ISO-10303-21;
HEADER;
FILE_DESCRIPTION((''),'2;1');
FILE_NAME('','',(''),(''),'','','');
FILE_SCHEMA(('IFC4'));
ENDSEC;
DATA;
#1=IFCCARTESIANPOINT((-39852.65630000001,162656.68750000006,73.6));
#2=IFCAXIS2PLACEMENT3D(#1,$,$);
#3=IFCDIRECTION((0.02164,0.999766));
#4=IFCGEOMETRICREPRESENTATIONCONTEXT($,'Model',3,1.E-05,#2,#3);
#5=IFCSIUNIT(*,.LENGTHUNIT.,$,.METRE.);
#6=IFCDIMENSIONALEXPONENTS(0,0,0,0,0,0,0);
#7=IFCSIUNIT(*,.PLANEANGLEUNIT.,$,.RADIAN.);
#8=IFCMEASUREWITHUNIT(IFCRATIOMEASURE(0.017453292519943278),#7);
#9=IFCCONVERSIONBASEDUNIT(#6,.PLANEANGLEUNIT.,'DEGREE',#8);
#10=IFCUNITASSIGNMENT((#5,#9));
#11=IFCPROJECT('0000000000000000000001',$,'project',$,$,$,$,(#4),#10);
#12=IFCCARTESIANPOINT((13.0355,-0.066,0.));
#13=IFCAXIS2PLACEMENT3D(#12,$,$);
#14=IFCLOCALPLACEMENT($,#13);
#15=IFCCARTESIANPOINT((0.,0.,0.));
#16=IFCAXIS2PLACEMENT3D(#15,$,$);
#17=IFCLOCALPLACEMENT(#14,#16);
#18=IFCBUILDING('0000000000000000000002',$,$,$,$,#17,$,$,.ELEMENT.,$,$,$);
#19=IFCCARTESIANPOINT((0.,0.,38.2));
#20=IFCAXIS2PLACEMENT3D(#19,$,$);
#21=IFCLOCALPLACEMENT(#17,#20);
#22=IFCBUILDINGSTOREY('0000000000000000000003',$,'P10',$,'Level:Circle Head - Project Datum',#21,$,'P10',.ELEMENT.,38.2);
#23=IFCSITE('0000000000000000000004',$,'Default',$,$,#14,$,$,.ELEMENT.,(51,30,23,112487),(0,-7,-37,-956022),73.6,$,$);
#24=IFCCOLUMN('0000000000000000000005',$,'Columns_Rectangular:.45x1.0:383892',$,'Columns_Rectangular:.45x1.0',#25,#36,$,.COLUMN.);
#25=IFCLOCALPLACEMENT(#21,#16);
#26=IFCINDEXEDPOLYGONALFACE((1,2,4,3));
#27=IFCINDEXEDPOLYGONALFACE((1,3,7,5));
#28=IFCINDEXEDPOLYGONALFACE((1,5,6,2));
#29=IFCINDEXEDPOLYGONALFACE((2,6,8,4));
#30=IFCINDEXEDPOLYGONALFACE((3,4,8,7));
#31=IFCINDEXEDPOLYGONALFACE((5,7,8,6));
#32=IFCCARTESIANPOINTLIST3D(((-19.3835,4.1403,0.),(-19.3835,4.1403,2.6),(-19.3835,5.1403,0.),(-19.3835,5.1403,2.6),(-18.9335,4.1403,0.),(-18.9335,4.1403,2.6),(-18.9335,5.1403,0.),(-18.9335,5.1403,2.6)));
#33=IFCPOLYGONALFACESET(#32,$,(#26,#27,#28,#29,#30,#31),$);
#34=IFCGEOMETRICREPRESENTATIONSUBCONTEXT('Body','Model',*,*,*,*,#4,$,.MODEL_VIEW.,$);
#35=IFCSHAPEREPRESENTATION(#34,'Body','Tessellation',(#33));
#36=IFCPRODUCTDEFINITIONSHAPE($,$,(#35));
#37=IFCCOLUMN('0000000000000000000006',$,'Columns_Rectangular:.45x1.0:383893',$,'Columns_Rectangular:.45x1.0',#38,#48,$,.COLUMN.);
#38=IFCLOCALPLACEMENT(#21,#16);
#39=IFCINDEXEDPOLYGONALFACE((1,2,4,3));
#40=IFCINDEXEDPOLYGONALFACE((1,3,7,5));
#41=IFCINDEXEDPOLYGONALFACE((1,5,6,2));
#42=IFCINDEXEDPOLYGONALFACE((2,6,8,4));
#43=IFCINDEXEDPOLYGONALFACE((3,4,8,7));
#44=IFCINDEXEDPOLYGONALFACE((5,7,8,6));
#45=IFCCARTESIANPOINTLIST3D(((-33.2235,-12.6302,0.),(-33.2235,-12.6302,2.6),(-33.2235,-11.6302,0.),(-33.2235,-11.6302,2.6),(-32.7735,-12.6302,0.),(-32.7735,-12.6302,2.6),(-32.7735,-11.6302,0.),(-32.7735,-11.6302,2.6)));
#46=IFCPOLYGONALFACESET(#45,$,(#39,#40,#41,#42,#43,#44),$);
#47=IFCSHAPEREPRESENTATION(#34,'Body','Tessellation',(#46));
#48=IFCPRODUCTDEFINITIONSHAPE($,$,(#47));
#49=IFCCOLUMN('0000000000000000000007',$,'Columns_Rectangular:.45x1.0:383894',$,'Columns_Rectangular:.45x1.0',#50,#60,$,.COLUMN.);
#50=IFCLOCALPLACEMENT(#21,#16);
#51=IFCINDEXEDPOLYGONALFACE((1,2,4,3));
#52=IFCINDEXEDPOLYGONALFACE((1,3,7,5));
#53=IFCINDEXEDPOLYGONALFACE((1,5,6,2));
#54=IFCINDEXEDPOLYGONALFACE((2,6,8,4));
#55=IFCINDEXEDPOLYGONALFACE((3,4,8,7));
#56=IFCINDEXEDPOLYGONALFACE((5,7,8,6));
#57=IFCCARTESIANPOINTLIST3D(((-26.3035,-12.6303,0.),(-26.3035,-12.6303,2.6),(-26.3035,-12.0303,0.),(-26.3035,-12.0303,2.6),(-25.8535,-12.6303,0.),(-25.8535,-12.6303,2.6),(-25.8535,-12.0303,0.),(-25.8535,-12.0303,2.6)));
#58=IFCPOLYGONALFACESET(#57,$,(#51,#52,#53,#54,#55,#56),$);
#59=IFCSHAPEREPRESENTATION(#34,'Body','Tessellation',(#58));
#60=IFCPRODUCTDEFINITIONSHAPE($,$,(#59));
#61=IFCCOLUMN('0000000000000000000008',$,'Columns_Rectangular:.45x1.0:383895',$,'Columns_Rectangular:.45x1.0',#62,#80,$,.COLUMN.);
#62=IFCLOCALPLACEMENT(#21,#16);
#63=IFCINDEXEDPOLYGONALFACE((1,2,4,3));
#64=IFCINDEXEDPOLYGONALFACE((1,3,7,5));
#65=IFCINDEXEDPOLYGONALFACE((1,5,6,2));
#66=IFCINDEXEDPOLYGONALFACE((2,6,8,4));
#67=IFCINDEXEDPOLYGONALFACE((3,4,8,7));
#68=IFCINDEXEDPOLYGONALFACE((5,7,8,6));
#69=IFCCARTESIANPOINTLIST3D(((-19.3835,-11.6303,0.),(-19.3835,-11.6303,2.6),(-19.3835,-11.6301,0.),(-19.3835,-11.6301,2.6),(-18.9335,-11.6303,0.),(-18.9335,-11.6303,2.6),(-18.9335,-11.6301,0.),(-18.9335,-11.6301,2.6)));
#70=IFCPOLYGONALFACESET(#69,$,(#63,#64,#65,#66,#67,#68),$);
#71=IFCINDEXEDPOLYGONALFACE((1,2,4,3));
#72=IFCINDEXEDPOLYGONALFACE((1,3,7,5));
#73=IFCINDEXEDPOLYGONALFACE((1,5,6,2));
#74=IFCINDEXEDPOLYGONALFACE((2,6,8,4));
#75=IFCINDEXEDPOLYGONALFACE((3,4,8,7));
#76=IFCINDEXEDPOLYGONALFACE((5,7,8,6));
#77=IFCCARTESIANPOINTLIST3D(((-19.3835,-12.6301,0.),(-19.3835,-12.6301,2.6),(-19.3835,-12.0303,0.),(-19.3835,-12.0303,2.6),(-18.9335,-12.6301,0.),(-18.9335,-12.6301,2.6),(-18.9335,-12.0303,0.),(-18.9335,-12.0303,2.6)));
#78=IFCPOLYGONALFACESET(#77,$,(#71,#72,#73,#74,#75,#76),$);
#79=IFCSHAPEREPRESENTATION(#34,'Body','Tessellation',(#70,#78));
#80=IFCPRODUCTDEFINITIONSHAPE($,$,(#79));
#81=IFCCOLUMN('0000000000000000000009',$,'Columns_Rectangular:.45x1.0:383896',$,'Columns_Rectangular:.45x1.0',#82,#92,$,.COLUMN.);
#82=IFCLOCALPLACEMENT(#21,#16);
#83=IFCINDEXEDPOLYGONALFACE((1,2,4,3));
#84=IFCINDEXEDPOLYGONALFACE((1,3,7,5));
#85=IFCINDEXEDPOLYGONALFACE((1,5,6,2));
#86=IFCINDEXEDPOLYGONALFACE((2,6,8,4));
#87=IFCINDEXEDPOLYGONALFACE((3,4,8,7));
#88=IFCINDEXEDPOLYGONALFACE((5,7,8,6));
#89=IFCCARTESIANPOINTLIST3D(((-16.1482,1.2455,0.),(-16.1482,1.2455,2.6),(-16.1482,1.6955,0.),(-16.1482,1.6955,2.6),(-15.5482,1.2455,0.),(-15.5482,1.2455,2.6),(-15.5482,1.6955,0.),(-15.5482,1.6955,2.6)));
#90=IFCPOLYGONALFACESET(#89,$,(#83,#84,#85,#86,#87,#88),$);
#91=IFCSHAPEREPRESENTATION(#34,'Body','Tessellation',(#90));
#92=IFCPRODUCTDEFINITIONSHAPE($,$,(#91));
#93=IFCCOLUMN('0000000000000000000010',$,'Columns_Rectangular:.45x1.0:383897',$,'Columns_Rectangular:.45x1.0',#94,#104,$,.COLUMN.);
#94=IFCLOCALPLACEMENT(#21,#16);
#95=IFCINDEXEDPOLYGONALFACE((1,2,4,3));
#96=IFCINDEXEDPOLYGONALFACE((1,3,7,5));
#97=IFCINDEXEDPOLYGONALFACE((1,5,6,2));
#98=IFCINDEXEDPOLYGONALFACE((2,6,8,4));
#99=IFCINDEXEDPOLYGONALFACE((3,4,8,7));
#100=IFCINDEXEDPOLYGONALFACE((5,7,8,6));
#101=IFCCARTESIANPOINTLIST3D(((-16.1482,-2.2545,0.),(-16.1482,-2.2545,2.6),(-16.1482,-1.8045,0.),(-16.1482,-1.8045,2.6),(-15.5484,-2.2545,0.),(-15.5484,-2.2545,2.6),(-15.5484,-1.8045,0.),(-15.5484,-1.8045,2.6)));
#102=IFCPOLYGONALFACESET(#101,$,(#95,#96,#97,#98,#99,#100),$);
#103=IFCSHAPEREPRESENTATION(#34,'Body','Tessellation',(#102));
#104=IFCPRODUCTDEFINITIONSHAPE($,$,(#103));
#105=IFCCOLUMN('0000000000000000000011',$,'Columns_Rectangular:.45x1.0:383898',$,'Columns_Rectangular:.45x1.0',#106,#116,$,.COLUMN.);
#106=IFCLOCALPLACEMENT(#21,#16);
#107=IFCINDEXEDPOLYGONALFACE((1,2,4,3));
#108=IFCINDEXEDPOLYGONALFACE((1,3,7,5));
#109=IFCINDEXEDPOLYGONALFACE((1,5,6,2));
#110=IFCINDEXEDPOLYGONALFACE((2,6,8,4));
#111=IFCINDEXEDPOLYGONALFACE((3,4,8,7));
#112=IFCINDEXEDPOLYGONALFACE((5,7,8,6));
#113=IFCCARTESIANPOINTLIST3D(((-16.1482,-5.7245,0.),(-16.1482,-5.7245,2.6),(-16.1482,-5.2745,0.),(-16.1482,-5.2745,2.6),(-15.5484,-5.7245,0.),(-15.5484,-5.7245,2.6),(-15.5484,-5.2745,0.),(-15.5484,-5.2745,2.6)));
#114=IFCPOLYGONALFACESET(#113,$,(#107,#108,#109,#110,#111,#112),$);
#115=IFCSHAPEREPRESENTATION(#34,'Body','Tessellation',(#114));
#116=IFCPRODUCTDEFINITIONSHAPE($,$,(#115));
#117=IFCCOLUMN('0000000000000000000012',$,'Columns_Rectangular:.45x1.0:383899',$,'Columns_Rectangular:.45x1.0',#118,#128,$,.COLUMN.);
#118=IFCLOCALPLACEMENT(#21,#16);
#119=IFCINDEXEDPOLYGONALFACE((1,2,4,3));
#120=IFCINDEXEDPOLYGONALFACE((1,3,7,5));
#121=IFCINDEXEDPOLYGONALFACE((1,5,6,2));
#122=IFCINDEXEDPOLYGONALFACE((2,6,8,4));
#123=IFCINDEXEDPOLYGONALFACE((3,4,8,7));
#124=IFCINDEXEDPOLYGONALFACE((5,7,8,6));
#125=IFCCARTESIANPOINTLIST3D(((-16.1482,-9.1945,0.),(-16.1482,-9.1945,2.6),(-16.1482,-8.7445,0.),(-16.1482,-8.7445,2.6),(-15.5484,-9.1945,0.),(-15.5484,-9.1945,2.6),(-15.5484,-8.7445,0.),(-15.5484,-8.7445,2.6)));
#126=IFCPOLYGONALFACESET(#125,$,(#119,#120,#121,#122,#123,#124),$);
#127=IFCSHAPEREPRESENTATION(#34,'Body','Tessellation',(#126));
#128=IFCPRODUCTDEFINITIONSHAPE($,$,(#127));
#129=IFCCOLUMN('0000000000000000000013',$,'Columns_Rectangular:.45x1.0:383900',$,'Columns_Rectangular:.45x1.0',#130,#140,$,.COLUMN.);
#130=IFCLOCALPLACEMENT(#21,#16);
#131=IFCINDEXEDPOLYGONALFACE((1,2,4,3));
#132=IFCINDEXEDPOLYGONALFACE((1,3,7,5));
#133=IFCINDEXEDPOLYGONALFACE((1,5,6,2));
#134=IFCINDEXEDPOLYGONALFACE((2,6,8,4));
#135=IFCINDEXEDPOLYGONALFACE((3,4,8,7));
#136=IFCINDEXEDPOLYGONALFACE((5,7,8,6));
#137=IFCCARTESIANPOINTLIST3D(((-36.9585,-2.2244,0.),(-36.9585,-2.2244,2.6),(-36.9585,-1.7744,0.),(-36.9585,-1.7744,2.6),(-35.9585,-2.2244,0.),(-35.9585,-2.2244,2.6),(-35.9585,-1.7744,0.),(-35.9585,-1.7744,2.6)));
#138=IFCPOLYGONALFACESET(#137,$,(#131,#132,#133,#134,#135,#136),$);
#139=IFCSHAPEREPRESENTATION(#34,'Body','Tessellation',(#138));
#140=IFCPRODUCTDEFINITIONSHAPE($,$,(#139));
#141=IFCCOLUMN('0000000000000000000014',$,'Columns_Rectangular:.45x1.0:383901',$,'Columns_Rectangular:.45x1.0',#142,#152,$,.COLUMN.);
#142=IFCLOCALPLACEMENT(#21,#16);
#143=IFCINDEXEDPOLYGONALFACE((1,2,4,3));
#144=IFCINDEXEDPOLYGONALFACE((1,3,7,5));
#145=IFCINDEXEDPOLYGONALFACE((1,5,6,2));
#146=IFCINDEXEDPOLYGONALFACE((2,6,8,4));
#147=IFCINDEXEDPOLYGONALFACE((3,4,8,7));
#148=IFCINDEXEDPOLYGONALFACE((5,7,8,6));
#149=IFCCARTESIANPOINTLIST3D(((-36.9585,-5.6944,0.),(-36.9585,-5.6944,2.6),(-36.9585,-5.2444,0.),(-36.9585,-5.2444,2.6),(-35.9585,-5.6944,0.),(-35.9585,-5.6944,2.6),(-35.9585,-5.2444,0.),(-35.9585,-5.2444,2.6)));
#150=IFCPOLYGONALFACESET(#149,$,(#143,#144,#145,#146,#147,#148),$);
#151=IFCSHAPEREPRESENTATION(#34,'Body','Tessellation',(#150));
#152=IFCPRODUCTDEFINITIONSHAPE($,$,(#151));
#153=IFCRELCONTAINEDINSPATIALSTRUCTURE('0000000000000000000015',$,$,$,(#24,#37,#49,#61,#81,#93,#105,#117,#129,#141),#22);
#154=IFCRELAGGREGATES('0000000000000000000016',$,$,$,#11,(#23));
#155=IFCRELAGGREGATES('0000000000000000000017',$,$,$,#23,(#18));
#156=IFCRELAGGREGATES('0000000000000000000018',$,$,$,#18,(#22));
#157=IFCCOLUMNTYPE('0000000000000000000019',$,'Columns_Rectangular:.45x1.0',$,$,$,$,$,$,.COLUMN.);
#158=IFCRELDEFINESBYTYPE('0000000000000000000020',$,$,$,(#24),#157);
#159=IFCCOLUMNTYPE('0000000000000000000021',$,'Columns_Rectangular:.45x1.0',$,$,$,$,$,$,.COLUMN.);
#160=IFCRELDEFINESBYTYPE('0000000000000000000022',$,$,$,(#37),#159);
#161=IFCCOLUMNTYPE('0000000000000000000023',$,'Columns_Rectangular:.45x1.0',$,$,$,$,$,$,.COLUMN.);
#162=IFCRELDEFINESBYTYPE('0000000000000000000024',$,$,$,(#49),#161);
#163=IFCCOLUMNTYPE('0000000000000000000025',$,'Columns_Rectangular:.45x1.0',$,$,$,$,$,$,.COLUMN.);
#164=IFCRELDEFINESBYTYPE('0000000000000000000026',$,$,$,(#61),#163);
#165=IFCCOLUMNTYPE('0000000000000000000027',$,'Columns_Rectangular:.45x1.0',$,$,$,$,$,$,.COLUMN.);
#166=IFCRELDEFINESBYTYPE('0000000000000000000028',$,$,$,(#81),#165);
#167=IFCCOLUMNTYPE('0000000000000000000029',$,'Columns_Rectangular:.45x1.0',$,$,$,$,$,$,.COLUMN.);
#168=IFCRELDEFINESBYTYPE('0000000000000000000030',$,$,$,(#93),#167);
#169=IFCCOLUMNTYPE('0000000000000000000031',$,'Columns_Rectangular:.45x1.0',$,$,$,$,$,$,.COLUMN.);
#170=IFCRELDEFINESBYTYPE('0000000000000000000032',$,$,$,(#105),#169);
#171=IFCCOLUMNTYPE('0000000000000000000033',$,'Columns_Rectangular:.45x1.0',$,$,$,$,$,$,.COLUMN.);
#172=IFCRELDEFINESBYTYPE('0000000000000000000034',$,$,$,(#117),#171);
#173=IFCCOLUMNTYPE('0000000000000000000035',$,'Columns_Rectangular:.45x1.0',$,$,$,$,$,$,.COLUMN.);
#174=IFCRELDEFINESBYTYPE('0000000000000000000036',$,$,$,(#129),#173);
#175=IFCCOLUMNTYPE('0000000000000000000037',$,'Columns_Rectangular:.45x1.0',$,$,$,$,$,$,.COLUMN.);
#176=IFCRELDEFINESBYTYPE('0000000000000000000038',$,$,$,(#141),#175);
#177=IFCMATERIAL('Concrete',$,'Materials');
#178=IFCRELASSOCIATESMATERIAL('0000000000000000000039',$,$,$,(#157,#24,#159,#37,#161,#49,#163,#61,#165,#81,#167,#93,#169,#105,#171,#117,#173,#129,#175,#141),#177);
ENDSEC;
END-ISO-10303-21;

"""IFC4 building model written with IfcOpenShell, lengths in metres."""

from ifc_helpers import new_model, entity, si_unit, converted_unit, direction, frame, origin, place, context, subcontext, project, spatial, indexed_curve, outline, extrude, source, transform, mapped, material, type_object, type_shapes, element, save


model = new_model("IFC4")

# Units and contexts
model_context = context("Model", 3, precision=1e-05, world=frame((-39852.65630000001, 162656.68750000006, 73.6)), true_north=direction((0.02164, 0.999766)))
body_context = subcontext(model_context, "Body", "Model", "MODEL_VIEW")
ifc_project = project(units=[si_unit("LENGTHUNIT", "METRE"), converted_unit("PLANEANGLEUNIT", "DEGREE", entity("IfcRatioMeasure", 0.017453292519943278), si_unit("PLANEANGLEUNIT", "RADIAN"), dimensions=[0, 0, 0, 0, 0, 0, 0])], contexts=[model_context])

# Site, building, storey
site_placement = place(None, frame((13.0355, -0.066, 0.0)))
site = spatial("IfcSite", under=ifc_project, at=site_placement, Name="Default", CompositionType="ELEMENT", RefLatitude=(51, 30, 23, 112487), RefLongitude=(0, -7, -37, -956022), RefElevation=73.6)
building_placement = place(site_placement, origin())
building = spatial("IfcBuilding", under=site, at=building_placement, CompositionType="ELEMENT")
storey_placement = place(building_placement, frame((0.0, 0.0, 38.2)))
storey = spatial("IfcBuildingStorey", under=building, at=storey_placement, Name="P10", ObjectType="Level:Circle Head - Project Datum", LongName="P10", CompositionType="ELEMENT", Elevation=38.2)

# Columns
ifc_material = material(Name="Concrete", Category="Materials")
column_type_1 = type_object("IfcColumnType", Name="Columns_Rectangular:.45x1.0", PredefinedType="COLUMN", material=ifc_material)
shared_shape_1 = source(origin(), body_context, "Body", "SweptSolid", [
    extrude(outline(indexed_curve([(-0.5, -0.225), (0.5, -0.225), (0.5, 0.225), (-0.5, 0.225), (-0.5, -0.225)], self_intersect=False)), frame((-19.1585, 4.6403, 38.2), z_axis=(0.0, 0.0, 1.0), x_axis=(0.000016, 1.0, 0.0)), (0.0, 0.0, 1.0), 2.6),
])
type_shapes(column_type_1, [shared_shape_1])
column_1_placement = place(storey_placement, frame((0.0, 0.0, -38.2)))
element("IfcColumn", 1, at=column_1_placement, inside=storey, type_object=column_type_1, material=ifc_material, Name="Columns_Rectangular:.45x1.0:383892", ObjectType="Columns_Rectangular:.45x1.0", PredefinedType="COLUMN", context=body_context, shape_type="MappedRepresentation", body=[
    mapped(shared_shape_1, transform((0.0, 0.0, 0.0), scale=1.0)),
])
column_type_2 = type_object("IfcColumnType", Name="Columns_Rectangular:.45x1.0", PredefinedType="COLUMN", material=ifc_material)
shared_shape_2 = source(origin(), body_context, "Body", "SweptSolid", [
    extrude(outline(indexed_curve([(-0.5, -0.225), (0.5, -0.225), (0.5, 0.225), (-0.5, 0.225), (-0.5, -0.225)], self_intersect=False)), frame((-32.9985, -12.1302, 38.2), z_axis=(0.0, 0.0, 1.0), x_axis=(-0.000005, 1.0, 0.0)), (0.0, 0.0, 1.0), 2.6),
])
type_shapes(column_type_2, [shared_shape_2])
column_2_placement = place(storey_placement, frame((0.0, 0.0, -38.2)))
element("IfcColumn", 2, at=column_2_placement, inside=storey, type_object=column_type_2, material=ifc_material, Name="Columns_Rectangular:.45x1.0:383893", ObjectType="Columns_Rectangular:.45x1.0", PredefinedType="COLUMN", context=body_context, shape_type="MappedRepresentation", body=[
    mapped(shared_shape_2, transform((0.0, 0.0, 0.0), scale=1.0)),
])
column_type_3 = type_object("IfcColumnType", Name="Columns_Rectangular:.45x1.0", PredefinedType="COLUMN", material=ifc_material)
shared_shape_3 = source(origin(), body_context, "Body", "SweptSolid", [
    extrude(outline(indexed_curve([(-0.3, -0.225), (0.3, -0.225), (0.3, 0.225), (-0.3, 0.225), (-0.3, -0.225)], self_intersect=False)), frame((-26.0785, -12.3303, 38.2), z_axis=(0.0, 0.0, 1.0), x_axis=(0.000011, 1.0, 0.0)), (0.0, 0.0, 1.0), 2.6),
])
type_shapes(column_type_3, [shared_shape_3])
column_3_placement = place(storey_placement, frame((0.0, 0.0, -38.2)))
element("IfcColumn", 3, at=column_3_placement, inside=storey, type_object=column_type_3, material=ifc_material, Name="Columns_Rectangular:.45x1.0:383894", ObjectType="Columns_Rectangular:.45x1.0", PredefinedType="COLUMN", context=body_context, shape_type="MappedRepresentation", body=[
    mapped(shared_shape_3, transform((0.0, 0.0, 0.0), scale=1.0)),
])
column_type_4 = type_object("IfcColumnType", Name="Columns_Rectangular:.45x1.0", PredefinedType="COLUMN", material=ifc_material)
shared_shape_4 = source(origin(), body_context, "Body", "SweptSolid", [
    extrude(outline(indexed_curve([(-0.225, -0.0001), (0.225, -0.0001), (0.225, 0.0001), (-0.225, 0.0001), (-0.225, -0.0001)], self_intersect=False)), frame((-19.1585, -11.6302, 38.2), z_axis=(0.0, 0.0, 1.0), x_axis=(-1.0, 0.000011, 0.0)), (0.0, 0.0, 1.0), 2.6),
    extrude(outline(indexed_curve([(-0.2999, -0.225), (0.2999, -0.225), (0.2999, 0.225), (-0.2999, 0.225), (-0.2999, -0.225)], self_intersect=False)), frame((-19.1585, -12.3302, 38.2), z_axis=(0.0, 0.0, 1.0), x_axis=(0.000011, 1.0, 0.0)), (0.0, 0.0, 1.0), 2.6),
])
type_shapes(column_type_4, [shared_shape_4])
column_4_placement = place(storey_placement, frame((0.0, 0.0, -38.2)))
element("IfcColumn", 4, at=column_4_placement, inside=storey, type_object=column_type_4, material=ifc_material, Name="Columns_Rectangular:.45x1.0:383895", ObjectType="Columns_Rectangular:.45x1.0", PredefinedType="COLUMN", context=body_context, shape_type="MappedRepresentation", body=[
    mapped(shared_shape_4, transform((0.0, 0.0, 0.0), scale=1.0)),
])
column_type_5 = type_object("IfcColumnType", Name="Columns_Rectangular:.45x1.0", PredefinedType="COLUMN", material=ifc_material)
shared_shape_5 = source(origin(), body_context, "Body", "SweptSolid", [
    extrude(outline(indexed_curve([(-0.225, -0.3), (0.225, -0.3), (0.225, 0.3), (-0.225, 0.3), (-0.225, -0.3)], self_intersect=False)), frame((-15.8482, 1.4705, 38.2), z_axis=(0.0, 0.0, 1.0), x_axis=(0.0, -1.0, 0.0)), (0.0, 0.0, 1.0), 2.6),
])
type_shapes(column_type_5, [shared_shape_5])
column_5_placement = place(storey_placement, frame((0.0, 0.0, -38.2)))
element("IfcColumn", 5, at=column_5_placement, inside=storey, type_object=column_type_5, material=ifc_material, Name="Columns_Rectangular:.45x1.0:383896", ObjectType="Columns_Rectangular:.45x1.0", PredefinedType="COLUMN", context=body_context, shape_type="MappedRepresentation", body=[
    mapped(shared_shape_5, transform((0.0, 0.0, 0.0), scale=1.0)),
])
column_type_6 = type_object("IfcColumnType", Name="Columns_Rectangular:.45x1.0", PredefinedType="COLUMN", material=ifc_material)
shared_shape_6 = source(origin(), body_context, "Body", "SweptSolid", [
    extrude(outline(indexed_curve([(-0.225, -0.2999), (0.225, -0.2999), (0.225, 0.2999), (-0.225, 0.2999), (-0.225, -0.2999)], self_intersect=False)), frame((-15.8483, -2.0295, 38.2), z_axis=(0.0, 0.0, 1.0), x_axis=(0.0, -1.0, 0.0)), (0.0, 0.0, 1.0), 2.6),
])
type_shapes(column_type_6, [shared_shape_6])
column_6_placement = place(storey_placement, frame((0.0, 0.0, -38.2)))
element("IfcColumn", 6, at=column_6_placement, inside=storey, type_object=column_type_6, material=ifc_material, Name="Columns_Rectangular:.45x1.0:383897", ObjectType="Columns_Rectangular:.45x1.0", PredefinedType="COLUMN", context=body_context, shape_type="MappedRepresentation", body=[
    mapped(shared_shape_6, transform((0.0, 0.0, 0.0), scale=1.0)),
])
column_type_7 = type_object("IfcColumnType", Name="Columns_Rectangular:.45x1.0", PredefinedType="COLUMN", material=ifc_material)
shared_shape_7 = source(origin(), body_context, "Body", "SweptSolid", [
    extrude(outline(indexed_curve([(-0.225, -0.2999), (0.225, -0.2999), (0.225, 0.2999), (-0.225, 0.2999), (-0.225, -0.2999)], self_intersect=False)), frame((-15.8483, -5.4995, 38.2), z_axis=(0.0, 0.0, 1.0), x_axis=(0.0, -1.0, 0.0)), (0.0, 0.0, 1.0), 2.6),
])
type_shapes(column_type_7, [shared_shape_7])
column_7_placement = place(storey_placement, frame((0.0, 0.0, -38.2)))
element("IfcColumn", 7, at=column_7_placement, inside=storey, type_object=column_type_7, material=ifc_material, Name="Columns_Rectangular:.45x1.0:383898", ObjectType="Columns_Rectangular:.45x1.0", PredefinedType="COLUMN", context=body_context, shape_type="MappedRepresentation", body=[
    mapped(shared_shape_7, transform((0.0, 0.0, 0.0), scale=1.0)),
])
column_type_8 = type_object("IfcColumnType", Name="Columns_Rectangular:.45x1.0", PredefinedType="COLUMN", material=ifc_material)
shared_shape_8 = source(origin(), body_context, "Body", "SweptSolid", [
    extrude(outline(indexed_curve([(-0.225, -0.2999), (0.225, -0.2999), (0.225, 0.2999), (-0.225, 0.2999), (-0.225, -0.2999)], self_intersect=False)), frame((-15.8483, -8.9695, 38.2), z_axis=(0.0, 0.0, 1.0), x_axis=(0.0, -1.0, 0.0)), (0.0, 0.0, 1.0), 2.6),
])
type_shapes(column_type_8, [shared_shape_8])
column_8_placement = place(storey_placement, frame((0.0, 0.0, -38.2)))
element("IfcColumn", 8, at=column_8_placement, inside=storey, type_object=column_type_8, material=ifc_material, Name="Columns_Rectangular:.45x1.0:383899", ObjectType="Columns_Rectangular:.45x1.0", PredefinedType="COLUMN", context=body_context, shape_type="MappedRepresentation", body=[
    mapped(shared_shape_8, transform((0.0, 0.0, 0.0), scale=1.0)),
])
column_type_9 = type_object("IfcColumnType", Name="Columns_Rectangular:.45x1.0", PredefinedType="COLUMN", material=ifc_material)
shared_shape_9 = source(origin(), body_context, "Body", "SweptSolid", [
    extrude(outline(indexed_curve([(-0.225, -0.5), (0.225, -0.5), (0.225, 0.5), (-0.225, 0.5), (-0.225, -0.5)], self_intersect=False)), frame((-36.4585, -1.9994, 38.2), z_axis=(0.0, 0.0, 1.0), x_axis=(0.0, -1.0, 0.0)), (0.0, 0.0, 1.0), 2.6),
])
type_shapes(column_type_9, [shared_shape_9])
column_9_placement = place(storey_placement, frame((0.0, 0.0, -38.2)))
element("IfcColumn", 9, at=column_9_placement, inside=storey, type_object=column_type_9, material=ifc_material, Name="Columns_Rectangular:.45x1.0:383900", ObjectType="Columns_Rectangular:.45x1.0", PredefinedType="COLUMN", context=body_context, shape_type="MappedRepresentation", body=[
    mapped(shared_shape_9, transform((0.0, 0.0, 0.0), scale=1.0)),
])
column_type_10 = type_object("IfcColumnType", Name="Columns_Rectangular:.45x1.0", PredefinedType="COLUMN", material=ifc_material)
shared_shape_10 = source(origin(), body_context, "Body", "SweptSolid", [
    extrude(outline(indexed_curve([(-0.225, -0.5), (0.225, -0.5), (0.225, 0.5), (-0.225, 0.5), (-0.225, -0.5)], self_intersect=False)), frame((-36.4585, -5.4694, 38.2), z_axis=(0.0, 0.0, 1.0), x_axis=(0.0, -1.0, 0.0)), (0.0, 0.0, 1.0), 2.6),
])
type_shapes(column_type_10, [shared_shape_10])
column_10_placement = place(storey_placement, frame((0.0, 0.0, -38.2)))
element("IfcColumn", 10, at=column_10_placement, inside=storey, type_object=column_type_10, material=ifc_material, Name="Columns_Rectangular:.45x1.0:383901", ObjectType="Columns_Rectangular:.45x1.0", PredefinedType="COLUMN", context=body_context, shape_type="MappedRepresentation", body=[
    mapped(shared_shape_10, transform((0.0, 0.0, 0.0), scale=1.0)),
])

save(model, "model.ifc")
